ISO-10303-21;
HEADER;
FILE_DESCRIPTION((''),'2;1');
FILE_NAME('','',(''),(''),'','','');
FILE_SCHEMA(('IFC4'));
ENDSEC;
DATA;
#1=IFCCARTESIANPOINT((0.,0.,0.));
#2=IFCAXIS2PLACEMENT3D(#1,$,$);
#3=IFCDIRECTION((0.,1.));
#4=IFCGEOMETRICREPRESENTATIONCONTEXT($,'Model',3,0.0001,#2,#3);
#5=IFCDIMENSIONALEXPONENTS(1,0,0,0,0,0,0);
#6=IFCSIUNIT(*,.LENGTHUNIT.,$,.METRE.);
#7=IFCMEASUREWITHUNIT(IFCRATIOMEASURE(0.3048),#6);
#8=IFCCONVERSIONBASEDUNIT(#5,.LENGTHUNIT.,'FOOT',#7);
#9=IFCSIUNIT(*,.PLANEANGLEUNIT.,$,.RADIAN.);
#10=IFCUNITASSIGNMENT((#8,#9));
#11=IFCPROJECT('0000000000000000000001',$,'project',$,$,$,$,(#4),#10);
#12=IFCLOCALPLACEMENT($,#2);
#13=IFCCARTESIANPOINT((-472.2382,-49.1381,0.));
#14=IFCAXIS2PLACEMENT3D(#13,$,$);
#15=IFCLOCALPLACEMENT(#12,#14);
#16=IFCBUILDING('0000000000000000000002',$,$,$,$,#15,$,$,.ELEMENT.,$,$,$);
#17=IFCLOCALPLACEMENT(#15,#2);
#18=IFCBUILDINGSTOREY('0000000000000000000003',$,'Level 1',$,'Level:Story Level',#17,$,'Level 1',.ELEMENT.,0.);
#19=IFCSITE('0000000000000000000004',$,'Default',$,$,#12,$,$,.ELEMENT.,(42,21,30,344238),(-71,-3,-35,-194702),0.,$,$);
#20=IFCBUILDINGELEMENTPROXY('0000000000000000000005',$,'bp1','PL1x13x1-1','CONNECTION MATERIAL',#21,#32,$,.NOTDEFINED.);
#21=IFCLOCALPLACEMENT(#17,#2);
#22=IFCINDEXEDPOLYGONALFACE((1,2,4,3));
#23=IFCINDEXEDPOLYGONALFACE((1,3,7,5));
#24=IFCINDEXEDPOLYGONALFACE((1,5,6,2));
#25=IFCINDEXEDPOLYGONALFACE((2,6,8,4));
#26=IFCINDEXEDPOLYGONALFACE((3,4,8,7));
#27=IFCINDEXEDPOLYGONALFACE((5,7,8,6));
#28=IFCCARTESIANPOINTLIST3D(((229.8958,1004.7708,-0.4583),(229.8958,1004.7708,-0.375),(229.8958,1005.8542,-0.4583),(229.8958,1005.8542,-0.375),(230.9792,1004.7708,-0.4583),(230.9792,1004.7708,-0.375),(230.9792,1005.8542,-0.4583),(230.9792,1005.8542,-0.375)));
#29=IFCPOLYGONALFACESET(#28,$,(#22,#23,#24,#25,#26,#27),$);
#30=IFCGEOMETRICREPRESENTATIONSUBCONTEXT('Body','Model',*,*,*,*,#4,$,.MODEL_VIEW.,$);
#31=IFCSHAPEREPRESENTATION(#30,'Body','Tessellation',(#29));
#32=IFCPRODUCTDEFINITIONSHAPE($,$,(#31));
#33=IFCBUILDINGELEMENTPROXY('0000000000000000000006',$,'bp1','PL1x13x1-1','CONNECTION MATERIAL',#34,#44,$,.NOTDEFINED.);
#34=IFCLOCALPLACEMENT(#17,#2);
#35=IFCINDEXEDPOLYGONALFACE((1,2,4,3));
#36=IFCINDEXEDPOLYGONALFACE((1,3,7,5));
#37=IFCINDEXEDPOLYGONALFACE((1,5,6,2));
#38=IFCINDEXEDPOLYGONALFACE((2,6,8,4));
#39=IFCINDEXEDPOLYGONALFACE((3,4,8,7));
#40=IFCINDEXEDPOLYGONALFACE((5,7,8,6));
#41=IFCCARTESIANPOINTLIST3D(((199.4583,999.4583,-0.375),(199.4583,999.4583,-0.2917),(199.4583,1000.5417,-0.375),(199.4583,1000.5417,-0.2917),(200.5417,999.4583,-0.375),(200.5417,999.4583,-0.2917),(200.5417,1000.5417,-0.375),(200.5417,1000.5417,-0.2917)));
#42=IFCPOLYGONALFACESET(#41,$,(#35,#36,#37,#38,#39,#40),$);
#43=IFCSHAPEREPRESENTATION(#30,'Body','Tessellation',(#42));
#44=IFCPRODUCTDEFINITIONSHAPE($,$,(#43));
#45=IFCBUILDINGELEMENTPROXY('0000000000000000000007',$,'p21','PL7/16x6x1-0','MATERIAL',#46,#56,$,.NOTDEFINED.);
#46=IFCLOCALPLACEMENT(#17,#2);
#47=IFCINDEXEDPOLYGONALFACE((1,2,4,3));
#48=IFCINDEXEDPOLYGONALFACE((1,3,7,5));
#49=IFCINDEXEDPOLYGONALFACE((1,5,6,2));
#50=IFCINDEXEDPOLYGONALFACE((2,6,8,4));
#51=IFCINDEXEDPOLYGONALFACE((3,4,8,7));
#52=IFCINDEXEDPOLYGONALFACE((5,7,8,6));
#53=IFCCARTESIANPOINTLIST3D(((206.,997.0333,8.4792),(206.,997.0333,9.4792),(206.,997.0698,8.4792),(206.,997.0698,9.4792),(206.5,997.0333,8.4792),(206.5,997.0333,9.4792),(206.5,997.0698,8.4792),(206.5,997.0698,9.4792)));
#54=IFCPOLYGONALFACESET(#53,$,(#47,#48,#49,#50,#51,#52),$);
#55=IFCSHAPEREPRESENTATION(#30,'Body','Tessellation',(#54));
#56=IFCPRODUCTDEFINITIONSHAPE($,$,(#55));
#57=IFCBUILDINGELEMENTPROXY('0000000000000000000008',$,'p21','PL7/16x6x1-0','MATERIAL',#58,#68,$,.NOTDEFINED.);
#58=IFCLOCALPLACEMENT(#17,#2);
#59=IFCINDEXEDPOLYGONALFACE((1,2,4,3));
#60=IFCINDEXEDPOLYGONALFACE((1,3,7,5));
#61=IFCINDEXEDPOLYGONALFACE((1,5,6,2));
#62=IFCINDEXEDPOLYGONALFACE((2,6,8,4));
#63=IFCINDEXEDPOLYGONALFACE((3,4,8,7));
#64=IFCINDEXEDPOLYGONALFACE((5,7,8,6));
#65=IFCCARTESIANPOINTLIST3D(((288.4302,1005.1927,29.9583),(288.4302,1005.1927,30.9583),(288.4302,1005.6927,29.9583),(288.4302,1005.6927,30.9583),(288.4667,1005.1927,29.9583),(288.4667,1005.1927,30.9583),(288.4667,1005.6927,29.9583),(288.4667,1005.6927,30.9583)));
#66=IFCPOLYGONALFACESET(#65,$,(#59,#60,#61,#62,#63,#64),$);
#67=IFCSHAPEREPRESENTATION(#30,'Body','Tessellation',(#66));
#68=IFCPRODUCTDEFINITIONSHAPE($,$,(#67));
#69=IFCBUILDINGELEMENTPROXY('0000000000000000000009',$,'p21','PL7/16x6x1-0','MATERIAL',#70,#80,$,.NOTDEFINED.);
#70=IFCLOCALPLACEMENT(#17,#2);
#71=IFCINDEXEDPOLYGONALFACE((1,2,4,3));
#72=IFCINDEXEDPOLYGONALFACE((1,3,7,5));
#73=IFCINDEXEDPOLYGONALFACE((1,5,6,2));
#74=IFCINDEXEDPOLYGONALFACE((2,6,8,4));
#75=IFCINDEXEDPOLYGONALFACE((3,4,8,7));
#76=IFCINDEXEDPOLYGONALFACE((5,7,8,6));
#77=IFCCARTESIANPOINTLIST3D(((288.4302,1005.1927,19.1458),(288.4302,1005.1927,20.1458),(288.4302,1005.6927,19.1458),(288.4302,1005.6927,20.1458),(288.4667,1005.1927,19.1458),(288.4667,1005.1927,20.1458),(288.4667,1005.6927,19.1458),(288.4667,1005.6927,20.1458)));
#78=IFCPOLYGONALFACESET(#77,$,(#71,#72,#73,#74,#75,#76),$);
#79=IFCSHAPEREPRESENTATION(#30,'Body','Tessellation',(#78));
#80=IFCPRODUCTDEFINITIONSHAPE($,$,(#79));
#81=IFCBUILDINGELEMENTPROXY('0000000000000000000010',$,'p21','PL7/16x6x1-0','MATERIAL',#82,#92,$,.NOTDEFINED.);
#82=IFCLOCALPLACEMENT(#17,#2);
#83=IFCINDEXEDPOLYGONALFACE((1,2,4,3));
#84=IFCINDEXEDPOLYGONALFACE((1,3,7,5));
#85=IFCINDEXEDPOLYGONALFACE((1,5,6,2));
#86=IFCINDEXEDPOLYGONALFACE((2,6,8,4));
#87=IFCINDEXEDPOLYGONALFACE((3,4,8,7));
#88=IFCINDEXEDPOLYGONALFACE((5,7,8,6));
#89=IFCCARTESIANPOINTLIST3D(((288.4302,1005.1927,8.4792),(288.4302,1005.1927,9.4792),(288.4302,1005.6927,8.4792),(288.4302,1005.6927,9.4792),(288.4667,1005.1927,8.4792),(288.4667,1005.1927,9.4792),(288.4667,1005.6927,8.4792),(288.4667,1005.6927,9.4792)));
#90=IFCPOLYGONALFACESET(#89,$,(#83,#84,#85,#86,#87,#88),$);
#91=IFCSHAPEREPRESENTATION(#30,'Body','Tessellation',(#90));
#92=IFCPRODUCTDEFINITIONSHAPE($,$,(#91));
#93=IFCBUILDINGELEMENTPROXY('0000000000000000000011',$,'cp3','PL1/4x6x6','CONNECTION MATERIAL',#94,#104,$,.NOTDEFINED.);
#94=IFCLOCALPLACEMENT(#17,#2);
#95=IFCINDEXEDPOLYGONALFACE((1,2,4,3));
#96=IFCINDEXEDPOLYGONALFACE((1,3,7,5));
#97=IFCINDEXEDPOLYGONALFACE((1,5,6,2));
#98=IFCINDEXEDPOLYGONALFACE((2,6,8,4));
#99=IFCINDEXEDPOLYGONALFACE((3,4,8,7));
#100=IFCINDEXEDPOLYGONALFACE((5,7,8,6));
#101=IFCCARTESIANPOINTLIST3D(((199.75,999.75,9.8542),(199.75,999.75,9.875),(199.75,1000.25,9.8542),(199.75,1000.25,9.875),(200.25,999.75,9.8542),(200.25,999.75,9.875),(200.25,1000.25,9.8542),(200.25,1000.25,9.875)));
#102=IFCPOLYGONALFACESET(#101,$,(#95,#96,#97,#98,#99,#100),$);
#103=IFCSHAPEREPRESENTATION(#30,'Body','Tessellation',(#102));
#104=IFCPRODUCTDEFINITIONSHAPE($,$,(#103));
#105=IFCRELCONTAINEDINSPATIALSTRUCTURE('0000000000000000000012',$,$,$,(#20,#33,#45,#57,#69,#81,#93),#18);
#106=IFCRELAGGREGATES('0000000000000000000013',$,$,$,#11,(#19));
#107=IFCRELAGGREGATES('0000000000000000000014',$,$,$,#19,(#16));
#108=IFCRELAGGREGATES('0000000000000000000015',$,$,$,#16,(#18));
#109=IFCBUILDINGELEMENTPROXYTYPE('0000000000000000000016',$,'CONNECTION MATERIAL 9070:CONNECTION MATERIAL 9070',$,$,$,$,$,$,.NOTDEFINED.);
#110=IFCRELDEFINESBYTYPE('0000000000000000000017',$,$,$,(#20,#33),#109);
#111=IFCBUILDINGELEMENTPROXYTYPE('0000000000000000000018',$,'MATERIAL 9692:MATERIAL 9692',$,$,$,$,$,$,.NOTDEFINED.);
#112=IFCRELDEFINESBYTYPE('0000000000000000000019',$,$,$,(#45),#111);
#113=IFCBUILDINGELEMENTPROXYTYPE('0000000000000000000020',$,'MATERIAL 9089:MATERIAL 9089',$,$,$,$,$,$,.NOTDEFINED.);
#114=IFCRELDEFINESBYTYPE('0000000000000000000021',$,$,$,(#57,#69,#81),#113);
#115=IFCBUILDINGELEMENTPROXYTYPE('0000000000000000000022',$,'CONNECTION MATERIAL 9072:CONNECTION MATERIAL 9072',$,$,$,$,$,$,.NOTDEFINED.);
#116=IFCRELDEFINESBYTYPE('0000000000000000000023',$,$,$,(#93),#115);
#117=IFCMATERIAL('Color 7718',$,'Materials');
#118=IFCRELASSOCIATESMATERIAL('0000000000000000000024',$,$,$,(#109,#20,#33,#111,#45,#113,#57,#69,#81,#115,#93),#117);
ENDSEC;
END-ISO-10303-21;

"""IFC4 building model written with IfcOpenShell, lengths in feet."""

from ifc_helpers import new_model, entity, si_unit, converted_unit, direction, frame, origin, origin_2d_with_axis, place, context, subcontext, project, spatial, rectangle, extrude, source, transform, mapped, material, type_object, type_shapes, element, save


model = new_model("IFC4")

# Units and contexts
model_context = context("Model", 3, precision=0.0001, world=origin(), true_north=direction((0.0, 1.0)))
body_context = subcontext(model_context, "Body", "Model", "MODEL_VIEW")
ifc_project = project(units=[converted_unit("LENGTHUNIT", "FOOT", entity("IfcRatioMeasure", 0.3048), si_unit("LENGTHUNIT", "METRE"), dimensions=[1, 0, 0, 0, 0, 0, 0]), si_unit("PLANEANGLEUNIT", "RADIAN")], contexts=[model_context])

# Site, building, storey
site_placement = place(None, origin())
site = spatial("IfcSite", under=ifc_project, at=site_placement, Name="Default", CompositionType="ELEMENT", RefLatitude=(42, 21, 30, 344238), RefLongitude=(-71, -3, -35, -194702), RefElevation=0.0)
building_placement = place(site_placement, frame((-472.2382, -49.1381, 0.0)))
building = spatial("IfcBuilding", under=site, at=building_placement, CompositionType="ELEMENT")
storey_placement = place(building_placement, origin())
storey = spatial("IfcBuildingStorey", under=building, at=storey_placement, Name="Level 1", ObjectType="Level:Story Level", LongName="Level 1", CompositionType="ELEMENT", Elevation=0.0)

# Building element proxies
ifc_material_1 = material(Name="Color 7718", Category="Materials")
building_element_proxy_type_1 = type_object("IfcBuildingElementProxyType", Name="CONNECTION MATERIAL 9070:CONNECTION MATERIAL 9070", PredefinedType="NOTDEFINED", material=ifc_material_1)
shared_shape_1 = source(origin(), body_context, "Body", "SweptSolid", [
    extrude(rectangle(XDim=1.0833, YDim=1.0833, at=origin_2d_with_axis()), frame((0.0, 0.0, -0.0833)), (0.0, 0.0, 1.0), 0.0833),
])
type_shapes(building_element_proxy_type_1, [shared_shape_1])
for number, where, name in (
    (1, (230.4375, 1005.3125, -0.375), "bp1"),
    (2, (200.0, 1000.0, -0.2917), "bp1"),
):
    element("IfcBuildingElementProxy", number, at=place(building_placement, frame(where)), inside=storey, type_object=building_element_proxy_type_1, material=ifc_material_1, Name=name, Description="PL1x13x1-1", ObjectType="CONNECTION MATERIAL", PredefinedType="NOTDEFINED", context=body_context, shape_type="MappedRepresentation", body=[
        mapped(shared_shape_1, transform((0.0, 0.0, 0.0), scale=1.0)),
    ])
building_element_proxy_type_2 = type_object("IfcBuildingElementProxyType", Name="MATERIAL 9692:MATERIAL 9692", PredefinedType="NOTDEFINED", material=ifc_material_1)
shared_shape_2 = source(origin(), body_context, "Body", "SweptSolid", [
    extrude(rectangle(XDim=1.0, YDim=0.5, at=origin_2d_with_axis()), frame((0.5, -0.25, -0.0365)), (0.0, 0.0, 1.0), 0.0365),
])
type_shapes(building_element_proxy_type_2, [shared_shape_2])
proxy_1_placement = place(building_placement, frame((206.5, 997.0333, 9.4792), z_axis=(0.0, -1.0, 0.0), x_axis=(0.0, 0.0, -1.0)))
element("IfcBuildingElementProxy", 3, at=proxy_1_placement, inside=storey, type_object=building_element_proxy_type_2, material=ifc_material_1, Name="p21", Description="PL7/16x6x1-0", ObjectType="MATERIAL", PredefinedType="NOTDEFINED", context=body_context, shape_type="MappedRepresentation", body=[
    mapped(shared_shape_2, transform((0.0, 0.0, 0.0), scale=1.0)),
])
building_element_proxy_type_3 = type_object("IfcBuildingElementProxyType", Name="MATERIAL 9089:MATERIAL 9089", PredefinedType="NOTDEFINED", material=ifc_material_1)
shared_shape_3 = source(origin(), body_context, "Body", "SweptSolid", [
    extrude(rectangle(XDim=1.0, YDim=0.5, at=origin_2d_with_axis()), frame((0.5, -0.25, 0.0)), (0.0, 0.0, 1.0), 0.0365),
])
type_shapes(building_element_proxy_type_3, [shared_shape_3])
for number, where, z_axis, x_axis, name in (
    (4, (288.4667, 1005.1927, 30.9583), (-1.0, 0.0, 0.0), (0.0, 0.0, -1.0), "p21"),
    (5, (288.4667, 1005.1927, 20.1458), (-1.0, 0.0, 0.0), (0.0, 0.0, -1.0), "p21"),
    (6, (288.4667, 1005.1927, 9.4792), (-1.0, 0.0, 0.0), (0.0, 0.0, -1.0), "p21"),
):
    element("IfcBuildingElementProxy", number, at=place(building_placement, frame(where, z_axis=z_axis, x_axis=x_axis)), inside=storey, type_object=building_element_proxy_type_3, material=ifc_material_1, Name=name, Description="PL7/16x6x1-0", ObjectType="MATERIAL", PredefinedType="NOTDEFINED", context=body_context, shape_type="MappedRepresentation", body=[
        mapped(shared_shape_3, transform((0.0, 0.0, 0.0), scale=1.0)),
    ])
building_element_proxy_type_4 = type_object("IfcBuildingElementProxyType", Name="CONNECTION MATERIAL 9072:CONNECTION MATERIAL 9072", PredefinedType="NOTDEFINED", material=ifc_material_1)
shared_shape_4 = source(origin(), body_context, "Body", "SweptSolid", [
    extrude(rectangle(XDim=0.5, YDim=0.5, at=origin_2d_with_axis()), frame((0.0, 0.0, -0.0208)), (0.0, 0.0, 1.0), 0.0208),
])
type_shapes(building_element_proxy_type_4, [shared_shape_4])
proxy_2_placement = place(building_placement, frame((200.0, 1000.0, 9.8542), z_axis=(0.0, 0.0, -1.0), x_axis=(1.0, 0.0, 0.0)))
element("IfcBuildingElementProxy", 7, at=proxy_2_placement, inside=storey, type_object=building_element_proxy_type_4, material=ifc_material_1, Name="cp3", Description="PL1/4x6x6", ObjectType="CONNECTION MATERIAL", PredefinedType="NOTDEFINED", context=body_context, shape_type="MappedRepresentation", body=[
    mapped(shared_shape_4, transform((0.0, 0.0, 0.0), scale=1.0)),
])

save(model, "model.ifc")
